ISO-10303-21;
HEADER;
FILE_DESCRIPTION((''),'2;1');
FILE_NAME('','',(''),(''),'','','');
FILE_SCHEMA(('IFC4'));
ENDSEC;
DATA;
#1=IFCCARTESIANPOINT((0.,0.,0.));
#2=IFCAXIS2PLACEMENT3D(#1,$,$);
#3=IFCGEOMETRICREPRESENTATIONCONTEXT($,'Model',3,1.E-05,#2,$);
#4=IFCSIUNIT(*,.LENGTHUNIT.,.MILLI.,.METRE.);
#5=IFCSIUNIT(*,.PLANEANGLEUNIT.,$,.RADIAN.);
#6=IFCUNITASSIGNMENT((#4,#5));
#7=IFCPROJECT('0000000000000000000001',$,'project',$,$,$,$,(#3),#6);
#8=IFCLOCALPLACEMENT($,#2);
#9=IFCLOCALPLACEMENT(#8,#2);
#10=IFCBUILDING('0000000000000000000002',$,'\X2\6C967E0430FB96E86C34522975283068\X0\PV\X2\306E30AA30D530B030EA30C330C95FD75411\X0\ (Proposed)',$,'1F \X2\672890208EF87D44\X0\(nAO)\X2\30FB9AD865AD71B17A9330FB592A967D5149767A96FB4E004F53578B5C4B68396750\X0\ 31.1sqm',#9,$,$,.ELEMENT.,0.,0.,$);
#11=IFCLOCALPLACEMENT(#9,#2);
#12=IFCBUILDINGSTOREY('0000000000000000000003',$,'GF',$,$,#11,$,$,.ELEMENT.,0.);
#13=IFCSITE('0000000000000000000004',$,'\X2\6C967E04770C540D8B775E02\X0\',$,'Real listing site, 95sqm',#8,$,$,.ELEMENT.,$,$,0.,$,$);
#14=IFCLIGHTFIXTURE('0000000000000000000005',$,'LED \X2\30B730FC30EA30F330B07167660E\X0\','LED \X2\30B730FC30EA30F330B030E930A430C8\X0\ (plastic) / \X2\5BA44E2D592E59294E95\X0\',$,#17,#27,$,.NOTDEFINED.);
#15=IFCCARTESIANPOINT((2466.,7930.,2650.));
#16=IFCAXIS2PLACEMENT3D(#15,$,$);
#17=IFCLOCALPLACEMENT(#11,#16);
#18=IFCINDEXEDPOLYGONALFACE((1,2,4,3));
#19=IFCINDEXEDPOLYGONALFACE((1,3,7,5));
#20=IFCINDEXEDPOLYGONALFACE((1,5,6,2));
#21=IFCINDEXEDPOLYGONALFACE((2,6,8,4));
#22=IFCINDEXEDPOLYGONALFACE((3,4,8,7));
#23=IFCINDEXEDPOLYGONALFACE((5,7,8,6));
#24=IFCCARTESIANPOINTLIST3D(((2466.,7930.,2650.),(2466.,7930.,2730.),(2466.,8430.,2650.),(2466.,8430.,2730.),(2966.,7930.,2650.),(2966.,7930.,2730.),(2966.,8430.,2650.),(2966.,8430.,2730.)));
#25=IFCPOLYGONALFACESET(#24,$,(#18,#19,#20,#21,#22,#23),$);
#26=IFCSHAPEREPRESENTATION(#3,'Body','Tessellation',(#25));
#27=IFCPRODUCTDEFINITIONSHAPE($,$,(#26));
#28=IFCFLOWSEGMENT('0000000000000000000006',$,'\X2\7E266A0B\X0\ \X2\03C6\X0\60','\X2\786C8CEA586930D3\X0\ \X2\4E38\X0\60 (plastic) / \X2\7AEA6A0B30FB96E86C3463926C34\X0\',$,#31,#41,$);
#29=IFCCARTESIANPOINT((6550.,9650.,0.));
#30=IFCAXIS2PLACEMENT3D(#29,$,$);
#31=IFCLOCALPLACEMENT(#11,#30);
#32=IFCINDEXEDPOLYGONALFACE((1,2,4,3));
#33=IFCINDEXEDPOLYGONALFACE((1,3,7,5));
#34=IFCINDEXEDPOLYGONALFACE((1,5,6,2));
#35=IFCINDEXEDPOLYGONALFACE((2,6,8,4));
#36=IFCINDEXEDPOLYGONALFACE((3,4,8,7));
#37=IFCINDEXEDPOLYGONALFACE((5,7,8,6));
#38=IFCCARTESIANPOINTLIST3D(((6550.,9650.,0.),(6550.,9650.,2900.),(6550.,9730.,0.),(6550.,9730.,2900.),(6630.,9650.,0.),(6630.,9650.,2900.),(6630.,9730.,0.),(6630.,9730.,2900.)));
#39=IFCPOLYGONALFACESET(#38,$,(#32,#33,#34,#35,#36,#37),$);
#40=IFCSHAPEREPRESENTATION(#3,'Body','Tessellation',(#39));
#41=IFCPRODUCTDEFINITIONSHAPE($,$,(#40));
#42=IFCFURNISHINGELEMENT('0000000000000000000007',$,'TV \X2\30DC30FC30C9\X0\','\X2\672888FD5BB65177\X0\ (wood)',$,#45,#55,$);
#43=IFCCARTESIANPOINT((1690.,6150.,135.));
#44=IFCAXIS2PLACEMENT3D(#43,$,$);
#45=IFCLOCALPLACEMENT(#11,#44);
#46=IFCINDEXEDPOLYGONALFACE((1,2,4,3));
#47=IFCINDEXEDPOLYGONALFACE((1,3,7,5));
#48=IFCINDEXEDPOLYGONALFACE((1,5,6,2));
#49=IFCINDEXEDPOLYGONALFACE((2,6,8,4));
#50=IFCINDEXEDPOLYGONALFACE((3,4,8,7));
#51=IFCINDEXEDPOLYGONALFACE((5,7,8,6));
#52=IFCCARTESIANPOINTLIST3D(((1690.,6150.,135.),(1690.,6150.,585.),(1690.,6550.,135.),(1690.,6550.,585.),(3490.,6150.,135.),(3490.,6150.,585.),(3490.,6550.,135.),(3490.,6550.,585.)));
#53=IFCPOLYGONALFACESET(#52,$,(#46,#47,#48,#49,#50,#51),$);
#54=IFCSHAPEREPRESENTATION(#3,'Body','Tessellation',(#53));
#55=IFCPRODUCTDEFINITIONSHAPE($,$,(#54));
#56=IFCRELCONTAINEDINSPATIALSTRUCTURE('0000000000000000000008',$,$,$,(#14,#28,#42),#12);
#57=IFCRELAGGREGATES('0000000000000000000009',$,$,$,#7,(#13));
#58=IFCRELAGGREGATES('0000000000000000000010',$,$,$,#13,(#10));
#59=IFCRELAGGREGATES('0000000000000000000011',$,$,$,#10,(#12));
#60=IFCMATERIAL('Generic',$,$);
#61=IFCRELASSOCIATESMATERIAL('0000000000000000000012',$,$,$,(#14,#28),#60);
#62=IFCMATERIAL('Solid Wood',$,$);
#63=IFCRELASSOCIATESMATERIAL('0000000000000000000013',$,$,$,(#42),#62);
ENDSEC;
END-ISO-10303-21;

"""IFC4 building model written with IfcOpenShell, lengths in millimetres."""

from ifc_helpers import new_model, si_unit, frame, frame_2d, origin, place, context, project, spatial, rectangle, extrude, material, element, save


model = new_model("IFC4")

# Units and contexts
model_context = context("Model", 3, precision=1e-05, world=origin())
ifc_project = project(units=[si_unit("LENGTHUNIT", "METRE", prefix="MILLI"), si_unit("PLANEANGLEUNIT", "RADIAN")], contexts=[model_context])

# Site, building, storey
site_placement = place(None, origin())
site = spatial("IfcSite", under=ifc_project, at=site_placement, Name="沖縄県名護市", ObjectType="Real listing site, 95sqm", CompositionType="ELEMENT", RefElevation=0.0)
building_placement = place(site_placement, origin())
building = spatial("IfcBuilding", under=site, at=building_placement, Name="沖縄・雨水利用とPVのオフグリッド志向 (Proposed)", ObjectType="1F 木造軸組(nAO)・高断熱窓・太陽光発電一体型屋根材 31.1sqm", CompositionType="ELEMENT", ElevationOfRefHeight=0.0, ElevationOfTerrain=0.0)
storey_placement = place(building_placement, origin())
storey = spatial("IfcBuildingStorey", under=building, at=storey_placement, Name="GF", CompositionType="ELEMENT", Elevation=0.0)

# Shared definitions
ifc_material_1 = material(Name="Solid Wood")

# Shared definitions
ifc_material_2 = material(Name="Generic")

# Light fixture
light_fixture_1_placement = place(storey_placement, frame((2466.0, 7930.0, 2650.0)))
element("IfcLightFixture", 1, at=light_fixture_1_placement, inside=storey, material=ifc_material_2, Name="LED シーリング照明", Description="LED シーリングライト (plastic) / 室中央天井", PredefinedType="NOTDEFINED", context=model_context, shape_type="SweptSolid", body=[
    extrude(rectangle(XDim=500.0, YDim=500.0, at=frame_2d((250.0, 250.0))), frame((2466.0, 7930.0, 2650.0)), (0.0, 0.0, 1.0), 80.0),
])

# Flow segment
flow_segment_placement = place(storey_placement, frame((6550.0, 9650.0, 0.0)))
element("IfcFlowSegment", 2, at=flow_segment_placement, inside=storey, material=ifc_material_2, Name="縦樋 φ60", Description="硬質塩ビ 丸60 (plastic) / 竪樋・雨水排水", context=model_context, shape_type="SweptSolid", body=[
    extrude(rectangle(XDim=80.0, YDim=80.0, at=frame_2d((40.0, 40.0))), frame((6550.0, 9650.0, 0.0)), (0.0, 0.0, 1.0), 2900.0),
])

# Furnishing element
furnishing_placement = place(storey_placement, frame((1690.0, 6150.0, 135.0)))
element("IfcFurnishingElement", 3, at=furnishing_placement, inside=storey, material=ifc_material_1, Name="TV ボード", Description="木製家具 (wood)", context=model_context, shape_type="SweptSolid", body=[
    extrude(rectangle(XDim=1800.0, YDim=400.0, at=frame_2d((900.0, 200.0))), frame((1690.0, 6150.0, 135.0)), (0.0, 0.0, 1.0), 450.0),
])

save(model, "model.ifc")
